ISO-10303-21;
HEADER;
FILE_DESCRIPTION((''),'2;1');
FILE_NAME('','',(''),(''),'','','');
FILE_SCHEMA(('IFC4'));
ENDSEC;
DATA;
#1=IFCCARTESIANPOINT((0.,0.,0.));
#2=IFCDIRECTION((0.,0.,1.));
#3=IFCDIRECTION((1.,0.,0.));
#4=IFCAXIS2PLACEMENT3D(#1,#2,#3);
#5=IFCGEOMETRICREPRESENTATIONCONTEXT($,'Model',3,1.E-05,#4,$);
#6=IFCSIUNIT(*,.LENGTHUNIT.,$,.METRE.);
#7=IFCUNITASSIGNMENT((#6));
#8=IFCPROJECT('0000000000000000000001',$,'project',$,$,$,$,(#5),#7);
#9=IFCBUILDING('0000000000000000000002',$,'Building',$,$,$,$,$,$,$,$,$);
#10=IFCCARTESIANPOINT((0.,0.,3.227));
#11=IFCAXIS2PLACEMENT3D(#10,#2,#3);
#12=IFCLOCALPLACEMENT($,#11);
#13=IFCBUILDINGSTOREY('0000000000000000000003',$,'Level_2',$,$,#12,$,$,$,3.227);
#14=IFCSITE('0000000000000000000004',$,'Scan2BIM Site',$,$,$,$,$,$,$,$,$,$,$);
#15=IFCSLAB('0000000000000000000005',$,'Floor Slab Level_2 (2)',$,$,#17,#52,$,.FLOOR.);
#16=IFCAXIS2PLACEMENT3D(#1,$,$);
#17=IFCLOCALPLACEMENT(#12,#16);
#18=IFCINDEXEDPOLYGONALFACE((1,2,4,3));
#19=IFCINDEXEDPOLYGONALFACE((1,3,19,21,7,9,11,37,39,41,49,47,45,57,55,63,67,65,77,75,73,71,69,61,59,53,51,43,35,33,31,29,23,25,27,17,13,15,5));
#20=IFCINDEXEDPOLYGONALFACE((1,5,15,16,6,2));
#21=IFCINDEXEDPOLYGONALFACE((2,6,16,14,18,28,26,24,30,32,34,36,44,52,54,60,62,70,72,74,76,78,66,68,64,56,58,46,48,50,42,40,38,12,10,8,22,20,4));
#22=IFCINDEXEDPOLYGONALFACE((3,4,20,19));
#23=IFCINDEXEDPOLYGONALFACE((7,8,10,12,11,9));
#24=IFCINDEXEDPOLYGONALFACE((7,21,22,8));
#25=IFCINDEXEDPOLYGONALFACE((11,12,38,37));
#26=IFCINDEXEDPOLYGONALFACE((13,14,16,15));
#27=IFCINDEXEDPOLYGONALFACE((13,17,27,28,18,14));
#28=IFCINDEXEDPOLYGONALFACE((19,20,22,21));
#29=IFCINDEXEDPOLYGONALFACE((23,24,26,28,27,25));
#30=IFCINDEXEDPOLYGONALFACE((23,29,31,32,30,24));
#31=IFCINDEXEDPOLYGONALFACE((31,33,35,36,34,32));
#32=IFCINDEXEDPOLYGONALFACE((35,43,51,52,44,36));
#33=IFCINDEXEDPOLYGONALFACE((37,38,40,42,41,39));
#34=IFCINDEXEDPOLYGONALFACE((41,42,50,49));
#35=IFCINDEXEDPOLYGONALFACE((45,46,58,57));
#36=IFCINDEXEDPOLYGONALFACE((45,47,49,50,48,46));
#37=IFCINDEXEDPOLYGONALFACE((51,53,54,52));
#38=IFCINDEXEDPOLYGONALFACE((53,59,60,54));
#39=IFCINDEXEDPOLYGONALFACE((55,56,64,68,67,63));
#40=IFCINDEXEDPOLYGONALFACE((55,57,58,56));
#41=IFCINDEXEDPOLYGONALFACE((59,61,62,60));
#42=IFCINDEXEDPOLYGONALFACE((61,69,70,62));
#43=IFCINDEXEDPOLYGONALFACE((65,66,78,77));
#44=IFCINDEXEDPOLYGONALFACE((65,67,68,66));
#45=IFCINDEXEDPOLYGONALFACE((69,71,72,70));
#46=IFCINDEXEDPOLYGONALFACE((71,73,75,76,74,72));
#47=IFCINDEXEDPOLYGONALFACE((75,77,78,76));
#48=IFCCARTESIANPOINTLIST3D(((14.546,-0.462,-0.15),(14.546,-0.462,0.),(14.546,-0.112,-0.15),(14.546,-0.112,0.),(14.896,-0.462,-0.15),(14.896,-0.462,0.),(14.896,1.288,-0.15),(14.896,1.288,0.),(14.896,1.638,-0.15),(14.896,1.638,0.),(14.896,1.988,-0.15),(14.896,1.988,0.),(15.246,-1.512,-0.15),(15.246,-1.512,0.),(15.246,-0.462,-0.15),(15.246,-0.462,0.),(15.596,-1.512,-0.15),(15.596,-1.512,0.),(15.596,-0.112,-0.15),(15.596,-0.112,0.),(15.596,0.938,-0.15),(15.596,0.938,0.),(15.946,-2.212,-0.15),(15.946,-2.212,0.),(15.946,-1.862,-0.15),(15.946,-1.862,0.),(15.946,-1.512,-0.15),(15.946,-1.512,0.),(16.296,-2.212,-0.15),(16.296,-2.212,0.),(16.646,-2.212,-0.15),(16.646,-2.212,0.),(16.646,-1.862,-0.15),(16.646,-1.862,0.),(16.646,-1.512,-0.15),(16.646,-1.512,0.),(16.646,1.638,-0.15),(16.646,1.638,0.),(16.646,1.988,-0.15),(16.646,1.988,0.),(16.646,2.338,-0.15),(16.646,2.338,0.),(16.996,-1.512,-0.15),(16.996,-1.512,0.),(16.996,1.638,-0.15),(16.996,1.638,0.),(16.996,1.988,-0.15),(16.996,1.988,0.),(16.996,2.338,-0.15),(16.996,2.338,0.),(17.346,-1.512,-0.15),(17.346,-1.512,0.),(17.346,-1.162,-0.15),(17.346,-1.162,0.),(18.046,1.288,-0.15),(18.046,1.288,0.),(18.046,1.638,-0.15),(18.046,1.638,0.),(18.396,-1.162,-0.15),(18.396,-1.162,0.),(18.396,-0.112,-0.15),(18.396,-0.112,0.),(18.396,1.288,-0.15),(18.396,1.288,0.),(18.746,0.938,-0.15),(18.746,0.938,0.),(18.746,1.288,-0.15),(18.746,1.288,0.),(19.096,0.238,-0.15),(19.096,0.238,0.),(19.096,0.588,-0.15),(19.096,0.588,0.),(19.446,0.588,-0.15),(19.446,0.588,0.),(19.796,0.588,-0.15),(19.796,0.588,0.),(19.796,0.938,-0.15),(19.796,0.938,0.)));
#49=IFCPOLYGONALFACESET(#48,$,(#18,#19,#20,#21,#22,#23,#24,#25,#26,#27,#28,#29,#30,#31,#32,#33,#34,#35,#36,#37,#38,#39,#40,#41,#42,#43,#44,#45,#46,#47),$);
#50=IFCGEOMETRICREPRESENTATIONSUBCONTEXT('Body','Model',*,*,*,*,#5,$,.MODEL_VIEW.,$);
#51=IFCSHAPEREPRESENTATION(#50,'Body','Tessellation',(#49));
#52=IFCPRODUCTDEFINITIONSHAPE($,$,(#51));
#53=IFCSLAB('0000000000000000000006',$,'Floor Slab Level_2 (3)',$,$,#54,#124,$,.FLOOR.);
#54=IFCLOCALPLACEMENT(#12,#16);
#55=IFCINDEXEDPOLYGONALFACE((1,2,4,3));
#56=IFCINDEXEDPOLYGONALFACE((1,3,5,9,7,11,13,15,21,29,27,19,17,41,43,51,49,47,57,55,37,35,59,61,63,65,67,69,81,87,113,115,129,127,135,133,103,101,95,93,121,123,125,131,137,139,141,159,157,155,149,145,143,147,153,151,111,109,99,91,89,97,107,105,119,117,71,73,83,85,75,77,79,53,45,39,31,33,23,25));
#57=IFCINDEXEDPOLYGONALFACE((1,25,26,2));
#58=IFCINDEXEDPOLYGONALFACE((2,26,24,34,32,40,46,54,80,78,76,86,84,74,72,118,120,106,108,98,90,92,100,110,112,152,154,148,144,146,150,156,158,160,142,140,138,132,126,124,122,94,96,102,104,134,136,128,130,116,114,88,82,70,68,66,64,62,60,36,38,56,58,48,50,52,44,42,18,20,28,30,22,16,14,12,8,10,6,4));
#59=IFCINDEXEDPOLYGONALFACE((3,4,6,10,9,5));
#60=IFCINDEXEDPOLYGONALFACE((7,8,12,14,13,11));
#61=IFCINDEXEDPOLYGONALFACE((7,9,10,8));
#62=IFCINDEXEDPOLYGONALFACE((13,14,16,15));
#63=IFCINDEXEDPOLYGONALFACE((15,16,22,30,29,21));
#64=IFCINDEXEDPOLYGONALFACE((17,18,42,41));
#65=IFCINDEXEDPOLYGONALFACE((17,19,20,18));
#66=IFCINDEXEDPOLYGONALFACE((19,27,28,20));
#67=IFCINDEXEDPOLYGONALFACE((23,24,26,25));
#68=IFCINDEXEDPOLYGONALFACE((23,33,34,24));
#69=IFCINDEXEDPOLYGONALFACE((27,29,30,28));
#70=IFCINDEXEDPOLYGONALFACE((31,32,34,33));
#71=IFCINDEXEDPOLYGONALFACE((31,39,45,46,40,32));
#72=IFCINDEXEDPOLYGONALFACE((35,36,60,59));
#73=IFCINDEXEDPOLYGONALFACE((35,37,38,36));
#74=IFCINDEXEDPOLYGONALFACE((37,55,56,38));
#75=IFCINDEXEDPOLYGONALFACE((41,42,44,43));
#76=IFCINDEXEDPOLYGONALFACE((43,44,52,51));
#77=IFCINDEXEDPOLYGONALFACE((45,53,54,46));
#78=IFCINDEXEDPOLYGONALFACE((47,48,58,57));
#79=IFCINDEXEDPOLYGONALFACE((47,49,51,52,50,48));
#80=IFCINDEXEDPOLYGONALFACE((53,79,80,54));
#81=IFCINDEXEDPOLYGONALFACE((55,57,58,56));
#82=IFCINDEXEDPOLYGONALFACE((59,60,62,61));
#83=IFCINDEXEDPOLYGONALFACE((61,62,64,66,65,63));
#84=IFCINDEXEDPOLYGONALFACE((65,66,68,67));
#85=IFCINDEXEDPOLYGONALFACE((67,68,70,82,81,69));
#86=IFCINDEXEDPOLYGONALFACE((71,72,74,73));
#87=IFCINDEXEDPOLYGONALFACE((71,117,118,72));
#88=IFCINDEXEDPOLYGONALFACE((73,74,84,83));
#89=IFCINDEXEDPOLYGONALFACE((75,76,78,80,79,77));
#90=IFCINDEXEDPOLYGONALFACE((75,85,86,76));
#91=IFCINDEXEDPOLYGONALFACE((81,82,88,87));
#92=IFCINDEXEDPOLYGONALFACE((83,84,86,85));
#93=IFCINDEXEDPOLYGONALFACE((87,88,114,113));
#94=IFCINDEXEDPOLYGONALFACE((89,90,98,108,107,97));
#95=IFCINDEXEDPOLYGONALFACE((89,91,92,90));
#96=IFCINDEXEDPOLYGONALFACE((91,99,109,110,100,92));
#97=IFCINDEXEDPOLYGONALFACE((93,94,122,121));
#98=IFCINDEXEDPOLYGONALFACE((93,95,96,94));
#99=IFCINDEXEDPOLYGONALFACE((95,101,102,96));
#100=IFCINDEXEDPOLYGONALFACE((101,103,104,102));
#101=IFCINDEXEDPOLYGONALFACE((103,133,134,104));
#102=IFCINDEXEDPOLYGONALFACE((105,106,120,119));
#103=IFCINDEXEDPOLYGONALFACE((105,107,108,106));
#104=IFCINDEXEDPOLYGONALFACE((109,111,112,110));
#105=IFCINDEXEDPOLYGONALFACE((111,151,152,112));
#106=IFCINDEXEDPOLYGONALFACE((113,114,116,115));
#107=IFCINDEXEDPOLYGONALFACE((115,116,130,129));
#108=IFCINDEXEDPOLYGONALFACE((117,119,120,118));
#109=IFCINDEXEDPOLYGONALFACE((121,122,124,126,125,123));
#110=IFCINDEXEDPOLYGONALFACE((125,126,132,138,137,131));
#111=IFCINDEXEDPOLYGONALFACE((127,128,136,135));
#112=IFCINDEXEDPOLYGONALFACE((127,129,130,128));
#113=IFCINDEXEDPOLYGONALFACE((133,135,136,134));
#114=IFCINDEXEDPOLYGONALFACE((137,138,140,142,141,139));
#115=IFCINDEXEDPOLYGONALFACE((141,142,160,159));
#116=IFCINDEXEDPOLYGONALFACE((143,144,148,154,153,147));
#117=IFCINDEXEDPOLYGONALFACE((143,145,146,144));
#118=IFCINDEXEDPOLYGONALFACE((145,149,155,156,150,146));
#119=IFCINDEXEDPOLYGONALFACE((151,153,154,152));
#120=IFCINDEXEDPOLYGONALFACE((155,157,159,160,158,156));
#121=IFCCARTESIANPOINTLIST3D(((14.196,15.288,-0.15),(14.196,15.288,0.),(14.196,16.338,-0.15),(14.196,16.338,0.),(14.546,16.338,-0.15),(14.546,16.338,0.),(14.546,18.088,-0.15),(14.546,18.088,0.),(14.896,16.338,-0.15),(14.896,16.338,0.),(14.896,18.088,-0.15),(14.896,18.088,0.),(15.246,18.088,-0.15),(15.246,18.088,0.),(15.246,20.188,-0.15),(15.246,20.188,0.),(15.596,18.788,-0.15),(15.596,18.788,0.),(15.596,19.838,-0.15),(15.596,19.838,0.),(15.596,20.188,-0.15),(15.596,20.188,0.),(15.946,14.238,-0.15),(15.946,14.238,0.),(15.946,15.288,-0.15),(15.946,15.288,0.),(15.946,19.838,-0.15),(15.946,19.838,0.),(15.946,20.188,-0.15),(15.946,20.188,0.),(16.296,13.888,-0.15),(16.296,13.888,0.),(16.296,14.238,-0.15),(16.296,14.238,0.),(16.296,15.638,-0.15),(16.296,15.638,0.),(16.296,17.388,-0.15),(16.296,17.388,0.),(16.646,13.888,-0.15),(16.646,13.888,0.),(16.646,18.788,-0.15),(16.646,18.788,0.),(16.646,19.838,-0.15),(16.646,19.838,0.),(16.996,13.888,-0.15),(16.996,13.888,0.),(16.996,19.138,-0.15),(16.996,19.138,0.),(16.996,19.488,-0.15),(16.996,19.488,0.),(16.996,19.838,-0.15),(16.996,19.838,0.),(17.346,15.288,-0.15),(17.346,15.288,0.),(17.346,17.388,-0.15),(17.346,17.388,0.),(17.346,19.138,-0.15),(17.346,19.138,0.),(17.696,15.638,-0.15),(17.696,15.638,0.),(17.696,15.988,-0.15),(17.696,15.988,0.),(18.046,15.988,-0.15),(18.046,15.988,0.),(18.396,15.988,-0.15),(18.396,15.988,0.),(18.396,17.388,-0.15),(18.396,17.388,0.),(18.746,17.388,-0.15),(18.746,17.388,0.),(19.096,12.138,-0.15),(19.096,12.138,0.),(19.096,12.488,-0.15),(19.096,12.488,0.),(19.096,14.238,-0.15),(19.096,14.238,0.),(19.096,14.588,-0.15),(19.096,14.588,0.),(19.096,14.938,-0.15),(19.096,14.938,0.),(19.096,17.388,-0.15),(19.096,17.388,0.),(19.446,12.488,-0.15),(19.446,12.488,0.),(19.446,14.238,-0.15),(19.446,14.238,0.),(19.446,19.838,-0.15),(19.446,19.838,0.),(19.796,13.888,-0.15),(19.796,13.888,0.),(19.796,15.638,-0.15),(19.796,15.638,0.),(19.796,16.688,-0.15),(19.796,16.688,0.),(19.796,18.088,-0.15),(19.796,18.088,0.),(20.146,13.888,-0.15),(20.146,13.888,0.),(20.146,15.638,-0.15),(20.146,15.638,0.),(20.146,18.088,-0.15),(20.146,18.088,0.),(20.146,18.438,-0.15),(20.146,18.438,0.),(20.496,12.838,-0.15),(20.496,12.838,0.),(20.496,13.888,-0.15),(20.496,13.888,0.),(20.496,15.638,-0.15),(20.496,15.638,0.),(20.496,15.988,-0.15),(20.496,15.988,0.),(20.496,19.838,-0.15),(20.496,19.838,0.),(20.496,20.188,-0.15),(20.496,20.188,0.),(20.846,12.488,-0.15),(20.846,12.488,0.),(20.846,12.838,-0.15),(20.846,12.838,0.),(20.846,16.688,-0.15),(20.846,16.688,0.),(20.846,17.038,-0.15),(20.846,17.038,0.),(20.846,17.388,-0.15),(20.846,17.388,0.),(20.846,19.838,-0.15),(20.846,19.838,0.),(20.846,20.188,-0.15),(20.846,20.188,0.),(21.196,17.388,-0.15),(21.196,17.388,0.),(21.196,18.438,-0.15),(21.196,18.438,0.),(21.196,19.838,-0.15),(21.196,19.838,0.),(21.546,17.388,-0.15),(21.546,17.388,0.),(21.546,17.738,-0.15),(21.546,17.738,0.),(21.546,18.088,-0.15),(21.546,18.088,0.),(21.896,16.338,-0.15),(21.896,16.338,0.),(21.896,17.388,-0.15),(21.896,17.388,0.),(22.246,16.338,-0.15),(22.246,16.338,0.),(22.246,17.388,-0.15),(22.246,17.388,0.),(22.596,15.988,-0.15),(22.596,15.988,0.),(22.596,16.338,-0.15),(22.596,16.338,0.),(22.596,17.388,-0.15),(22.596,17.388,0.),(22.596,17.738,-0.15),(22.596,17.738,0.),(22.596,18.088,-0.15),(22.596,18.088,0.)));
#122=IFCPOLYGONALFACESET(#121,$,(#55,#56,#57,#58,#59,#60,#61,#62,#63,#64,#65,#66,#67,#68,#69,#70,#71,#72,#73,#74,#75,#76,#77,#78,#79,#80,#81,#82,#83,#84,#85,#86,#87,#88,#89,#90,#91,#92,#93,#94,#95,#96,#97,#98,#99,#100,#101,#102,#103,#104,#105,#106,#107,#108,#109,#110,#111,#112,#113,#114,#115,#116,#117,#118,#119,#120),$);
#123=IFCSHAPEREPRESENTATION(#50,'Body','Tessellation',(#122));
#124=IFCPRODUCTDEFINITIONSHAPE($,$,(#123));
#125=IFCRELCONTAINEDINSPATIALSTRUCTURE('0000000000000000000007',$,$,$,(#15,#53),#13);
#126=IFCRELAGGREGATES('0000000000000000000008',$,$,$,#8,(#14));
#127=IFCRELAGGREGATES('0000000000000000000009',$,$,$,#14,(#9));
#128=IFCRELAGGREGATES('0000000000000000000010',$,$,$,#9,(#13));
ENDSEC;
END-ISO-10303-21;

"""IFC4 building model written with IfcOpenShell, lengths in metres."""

from ifc_helpers import new_model, si_unit, frame, origin, origin_with_axes, place, context, subcontext, project, spatial, polyline, outline, extrude, element, save


model = new_model("IFC4")

# Units and contexts
model_context = context("Model", 3, precision=1e-05, world=origin_with_axes())
body_context = subcontext(model_context, "Body", "Model", "MODEL_VIEW")
ifc_project = project(units=[si_unit("LENGTHUNIT", "METRE")], contexts=[model_context])

# Site, building, storey
site = spatial("IfcSite", under=ifc_project, Name="Scan2BIM Site")
building = spatial("IfcBuilding", under=site, Name="Building")
storey_placement = place(None, frame((0.0, 0.0, 3.227), z_axis=(0.0, 0.0, 1.0), x_axis=(1.0, 0.0, 0.0)))
storey = spatial("IfcBuildingStorey", under=building, at=storey_placement, Name="Level_2", Elevation=3.227)

# Slabs
slab_1_placement = place(storey_placement, frame((0.0, 0.0, -0.15), z_axis=(0.0, 0.0, 1.0), x_axis=(1.0, 0.0, 0.0)))
element("IfcSlab", 1, at=slab_1_placement, inside=storey, Name="Floor Slab Level_2 (2)", PredefinedType="FLOOR", context=body_context, shape_type="SweptSolid", body=[
    extrude(outline(polyline([(15.946, -2.212), (16.296, -2.212), (16.646, -2.212), (16.646, -1.862), (16.646, -1.512), (16.996, -1.512), (17.346, -1.512), (17.346, -1.162), (18.396, -1.162), (18.396, -0.112), (19.096, 0.238), (19.096, 0.588), (19.446, 0.588), (19.796, 0.588), (19.796, 0.938), (18.746, 0.938), (18.746, 1.288), (18.396, 1.288), (18.046, 1.288), (18.046, 1.638), (16.996, 1.638), (16.996, 1.988), (16.996, 2.338), (16.646, 2.338), (16.646, 1.988), (16.646, 1.638), (14.896, 1.988), (14.896, 1.638), (14.896, 1.288), (15.596, 0.938), (15.596, -0.112), (14.546, -0.112), (14.546, -0.462), (14.896, -0.462), (15.246, -0.462), (15.246, -1.512), (15.596, -1.512), (15.946, -1.512), (15.946, -1.862), (15.946, -2.212)])), origin(), (0.0, 0.0, 1.0), 0.15),
])
slab_2_placement = place(storey_placement, frame((0.0, 0.0, -0.15), z_axis=(0.0, 0.0, 1.0), x_axis=(1.0, 0.0, 0.0)))
element("IfcSlab", 2, at=slab_2_placement, inside=storey, Name="Floor Slab Level_2 (3)", PredefinedType="FLOOR", context=body_context, shape_type="SweptSolid", body=[
    extrude(outline(polyline([(19.096, 12.138), (20.846, 12.488), (20.846, 12.838), (20.496, 12.838), (20.496, 13.888), (20.146, 13.888), (19.796, 13.888), (19.796, 15.638), (20.146, 15.638), (20.496, 15.638), (20.496, 15.988), (22.596, 15.988), (22.596, 16.338), (22.246, 16.338), (21.896, 16.338), (21.896, 17.388), (22.246, 17.388), (22.596, 17.388), (22.596, 17.738), (22.596, 18.088), (21.546, 18.088), (21.546, 17.738), (21.546, 17.388), (21.196, 17.388), (20.846, 17.388), (20.846, 17.038), (20.846, 16.688), (19.796, 16.688), (19.796, 18.088), (20.146, 18.088), (20.146, 18.438), (21.196, 18.438), (21.196, 19.838), (20.846, 19.838), (20.846, 20.188), (20.496, 20.188), (20.496, 19.838), (19.446, 19.838), (19.096, 17.388), (18.746, 17.388), (18.396, 17.388), (18.396, 15.988), (18.046, 15.988), (17.696, 15.988), (17.696, 15.638), (16.296, 15.638), (16.296, 17.388), (17.346, 17.388), (17.346, 19.138), (16.996, 19.138), (16.996, 19.488), (16.996, 19.838), (16.646, 19.838), (16.646, 18.788), (15.596, 18.788), (15.596, 19.838), (15.946, 19.838), (15.946, 20.188), (15.596, 20.188), (15.246, 20.188), (15.246, 18.088), (14.896, 18.088), (14.546, 18.088), (14.896, 16.338), (14.546, 16.338), (14.196, 16.338), (14.196, 15.288), (15.946, 15.288), (15.946, 14.238), (16.296, 14.238), (16.296, 13.888), (16.646, 13.888), (16.996, 13.888), (17.346, 15.288), (19.096, 14.938), (19.096, 14.588), (19.096, 14.238), (19.446, 14.238), (19.446, 12.488), (19.096, 12.488), (19.096, 12.138)])), origin(), (0.0, 0.0, 1.0), 0.15),
])

save(model, "model.ifc")
